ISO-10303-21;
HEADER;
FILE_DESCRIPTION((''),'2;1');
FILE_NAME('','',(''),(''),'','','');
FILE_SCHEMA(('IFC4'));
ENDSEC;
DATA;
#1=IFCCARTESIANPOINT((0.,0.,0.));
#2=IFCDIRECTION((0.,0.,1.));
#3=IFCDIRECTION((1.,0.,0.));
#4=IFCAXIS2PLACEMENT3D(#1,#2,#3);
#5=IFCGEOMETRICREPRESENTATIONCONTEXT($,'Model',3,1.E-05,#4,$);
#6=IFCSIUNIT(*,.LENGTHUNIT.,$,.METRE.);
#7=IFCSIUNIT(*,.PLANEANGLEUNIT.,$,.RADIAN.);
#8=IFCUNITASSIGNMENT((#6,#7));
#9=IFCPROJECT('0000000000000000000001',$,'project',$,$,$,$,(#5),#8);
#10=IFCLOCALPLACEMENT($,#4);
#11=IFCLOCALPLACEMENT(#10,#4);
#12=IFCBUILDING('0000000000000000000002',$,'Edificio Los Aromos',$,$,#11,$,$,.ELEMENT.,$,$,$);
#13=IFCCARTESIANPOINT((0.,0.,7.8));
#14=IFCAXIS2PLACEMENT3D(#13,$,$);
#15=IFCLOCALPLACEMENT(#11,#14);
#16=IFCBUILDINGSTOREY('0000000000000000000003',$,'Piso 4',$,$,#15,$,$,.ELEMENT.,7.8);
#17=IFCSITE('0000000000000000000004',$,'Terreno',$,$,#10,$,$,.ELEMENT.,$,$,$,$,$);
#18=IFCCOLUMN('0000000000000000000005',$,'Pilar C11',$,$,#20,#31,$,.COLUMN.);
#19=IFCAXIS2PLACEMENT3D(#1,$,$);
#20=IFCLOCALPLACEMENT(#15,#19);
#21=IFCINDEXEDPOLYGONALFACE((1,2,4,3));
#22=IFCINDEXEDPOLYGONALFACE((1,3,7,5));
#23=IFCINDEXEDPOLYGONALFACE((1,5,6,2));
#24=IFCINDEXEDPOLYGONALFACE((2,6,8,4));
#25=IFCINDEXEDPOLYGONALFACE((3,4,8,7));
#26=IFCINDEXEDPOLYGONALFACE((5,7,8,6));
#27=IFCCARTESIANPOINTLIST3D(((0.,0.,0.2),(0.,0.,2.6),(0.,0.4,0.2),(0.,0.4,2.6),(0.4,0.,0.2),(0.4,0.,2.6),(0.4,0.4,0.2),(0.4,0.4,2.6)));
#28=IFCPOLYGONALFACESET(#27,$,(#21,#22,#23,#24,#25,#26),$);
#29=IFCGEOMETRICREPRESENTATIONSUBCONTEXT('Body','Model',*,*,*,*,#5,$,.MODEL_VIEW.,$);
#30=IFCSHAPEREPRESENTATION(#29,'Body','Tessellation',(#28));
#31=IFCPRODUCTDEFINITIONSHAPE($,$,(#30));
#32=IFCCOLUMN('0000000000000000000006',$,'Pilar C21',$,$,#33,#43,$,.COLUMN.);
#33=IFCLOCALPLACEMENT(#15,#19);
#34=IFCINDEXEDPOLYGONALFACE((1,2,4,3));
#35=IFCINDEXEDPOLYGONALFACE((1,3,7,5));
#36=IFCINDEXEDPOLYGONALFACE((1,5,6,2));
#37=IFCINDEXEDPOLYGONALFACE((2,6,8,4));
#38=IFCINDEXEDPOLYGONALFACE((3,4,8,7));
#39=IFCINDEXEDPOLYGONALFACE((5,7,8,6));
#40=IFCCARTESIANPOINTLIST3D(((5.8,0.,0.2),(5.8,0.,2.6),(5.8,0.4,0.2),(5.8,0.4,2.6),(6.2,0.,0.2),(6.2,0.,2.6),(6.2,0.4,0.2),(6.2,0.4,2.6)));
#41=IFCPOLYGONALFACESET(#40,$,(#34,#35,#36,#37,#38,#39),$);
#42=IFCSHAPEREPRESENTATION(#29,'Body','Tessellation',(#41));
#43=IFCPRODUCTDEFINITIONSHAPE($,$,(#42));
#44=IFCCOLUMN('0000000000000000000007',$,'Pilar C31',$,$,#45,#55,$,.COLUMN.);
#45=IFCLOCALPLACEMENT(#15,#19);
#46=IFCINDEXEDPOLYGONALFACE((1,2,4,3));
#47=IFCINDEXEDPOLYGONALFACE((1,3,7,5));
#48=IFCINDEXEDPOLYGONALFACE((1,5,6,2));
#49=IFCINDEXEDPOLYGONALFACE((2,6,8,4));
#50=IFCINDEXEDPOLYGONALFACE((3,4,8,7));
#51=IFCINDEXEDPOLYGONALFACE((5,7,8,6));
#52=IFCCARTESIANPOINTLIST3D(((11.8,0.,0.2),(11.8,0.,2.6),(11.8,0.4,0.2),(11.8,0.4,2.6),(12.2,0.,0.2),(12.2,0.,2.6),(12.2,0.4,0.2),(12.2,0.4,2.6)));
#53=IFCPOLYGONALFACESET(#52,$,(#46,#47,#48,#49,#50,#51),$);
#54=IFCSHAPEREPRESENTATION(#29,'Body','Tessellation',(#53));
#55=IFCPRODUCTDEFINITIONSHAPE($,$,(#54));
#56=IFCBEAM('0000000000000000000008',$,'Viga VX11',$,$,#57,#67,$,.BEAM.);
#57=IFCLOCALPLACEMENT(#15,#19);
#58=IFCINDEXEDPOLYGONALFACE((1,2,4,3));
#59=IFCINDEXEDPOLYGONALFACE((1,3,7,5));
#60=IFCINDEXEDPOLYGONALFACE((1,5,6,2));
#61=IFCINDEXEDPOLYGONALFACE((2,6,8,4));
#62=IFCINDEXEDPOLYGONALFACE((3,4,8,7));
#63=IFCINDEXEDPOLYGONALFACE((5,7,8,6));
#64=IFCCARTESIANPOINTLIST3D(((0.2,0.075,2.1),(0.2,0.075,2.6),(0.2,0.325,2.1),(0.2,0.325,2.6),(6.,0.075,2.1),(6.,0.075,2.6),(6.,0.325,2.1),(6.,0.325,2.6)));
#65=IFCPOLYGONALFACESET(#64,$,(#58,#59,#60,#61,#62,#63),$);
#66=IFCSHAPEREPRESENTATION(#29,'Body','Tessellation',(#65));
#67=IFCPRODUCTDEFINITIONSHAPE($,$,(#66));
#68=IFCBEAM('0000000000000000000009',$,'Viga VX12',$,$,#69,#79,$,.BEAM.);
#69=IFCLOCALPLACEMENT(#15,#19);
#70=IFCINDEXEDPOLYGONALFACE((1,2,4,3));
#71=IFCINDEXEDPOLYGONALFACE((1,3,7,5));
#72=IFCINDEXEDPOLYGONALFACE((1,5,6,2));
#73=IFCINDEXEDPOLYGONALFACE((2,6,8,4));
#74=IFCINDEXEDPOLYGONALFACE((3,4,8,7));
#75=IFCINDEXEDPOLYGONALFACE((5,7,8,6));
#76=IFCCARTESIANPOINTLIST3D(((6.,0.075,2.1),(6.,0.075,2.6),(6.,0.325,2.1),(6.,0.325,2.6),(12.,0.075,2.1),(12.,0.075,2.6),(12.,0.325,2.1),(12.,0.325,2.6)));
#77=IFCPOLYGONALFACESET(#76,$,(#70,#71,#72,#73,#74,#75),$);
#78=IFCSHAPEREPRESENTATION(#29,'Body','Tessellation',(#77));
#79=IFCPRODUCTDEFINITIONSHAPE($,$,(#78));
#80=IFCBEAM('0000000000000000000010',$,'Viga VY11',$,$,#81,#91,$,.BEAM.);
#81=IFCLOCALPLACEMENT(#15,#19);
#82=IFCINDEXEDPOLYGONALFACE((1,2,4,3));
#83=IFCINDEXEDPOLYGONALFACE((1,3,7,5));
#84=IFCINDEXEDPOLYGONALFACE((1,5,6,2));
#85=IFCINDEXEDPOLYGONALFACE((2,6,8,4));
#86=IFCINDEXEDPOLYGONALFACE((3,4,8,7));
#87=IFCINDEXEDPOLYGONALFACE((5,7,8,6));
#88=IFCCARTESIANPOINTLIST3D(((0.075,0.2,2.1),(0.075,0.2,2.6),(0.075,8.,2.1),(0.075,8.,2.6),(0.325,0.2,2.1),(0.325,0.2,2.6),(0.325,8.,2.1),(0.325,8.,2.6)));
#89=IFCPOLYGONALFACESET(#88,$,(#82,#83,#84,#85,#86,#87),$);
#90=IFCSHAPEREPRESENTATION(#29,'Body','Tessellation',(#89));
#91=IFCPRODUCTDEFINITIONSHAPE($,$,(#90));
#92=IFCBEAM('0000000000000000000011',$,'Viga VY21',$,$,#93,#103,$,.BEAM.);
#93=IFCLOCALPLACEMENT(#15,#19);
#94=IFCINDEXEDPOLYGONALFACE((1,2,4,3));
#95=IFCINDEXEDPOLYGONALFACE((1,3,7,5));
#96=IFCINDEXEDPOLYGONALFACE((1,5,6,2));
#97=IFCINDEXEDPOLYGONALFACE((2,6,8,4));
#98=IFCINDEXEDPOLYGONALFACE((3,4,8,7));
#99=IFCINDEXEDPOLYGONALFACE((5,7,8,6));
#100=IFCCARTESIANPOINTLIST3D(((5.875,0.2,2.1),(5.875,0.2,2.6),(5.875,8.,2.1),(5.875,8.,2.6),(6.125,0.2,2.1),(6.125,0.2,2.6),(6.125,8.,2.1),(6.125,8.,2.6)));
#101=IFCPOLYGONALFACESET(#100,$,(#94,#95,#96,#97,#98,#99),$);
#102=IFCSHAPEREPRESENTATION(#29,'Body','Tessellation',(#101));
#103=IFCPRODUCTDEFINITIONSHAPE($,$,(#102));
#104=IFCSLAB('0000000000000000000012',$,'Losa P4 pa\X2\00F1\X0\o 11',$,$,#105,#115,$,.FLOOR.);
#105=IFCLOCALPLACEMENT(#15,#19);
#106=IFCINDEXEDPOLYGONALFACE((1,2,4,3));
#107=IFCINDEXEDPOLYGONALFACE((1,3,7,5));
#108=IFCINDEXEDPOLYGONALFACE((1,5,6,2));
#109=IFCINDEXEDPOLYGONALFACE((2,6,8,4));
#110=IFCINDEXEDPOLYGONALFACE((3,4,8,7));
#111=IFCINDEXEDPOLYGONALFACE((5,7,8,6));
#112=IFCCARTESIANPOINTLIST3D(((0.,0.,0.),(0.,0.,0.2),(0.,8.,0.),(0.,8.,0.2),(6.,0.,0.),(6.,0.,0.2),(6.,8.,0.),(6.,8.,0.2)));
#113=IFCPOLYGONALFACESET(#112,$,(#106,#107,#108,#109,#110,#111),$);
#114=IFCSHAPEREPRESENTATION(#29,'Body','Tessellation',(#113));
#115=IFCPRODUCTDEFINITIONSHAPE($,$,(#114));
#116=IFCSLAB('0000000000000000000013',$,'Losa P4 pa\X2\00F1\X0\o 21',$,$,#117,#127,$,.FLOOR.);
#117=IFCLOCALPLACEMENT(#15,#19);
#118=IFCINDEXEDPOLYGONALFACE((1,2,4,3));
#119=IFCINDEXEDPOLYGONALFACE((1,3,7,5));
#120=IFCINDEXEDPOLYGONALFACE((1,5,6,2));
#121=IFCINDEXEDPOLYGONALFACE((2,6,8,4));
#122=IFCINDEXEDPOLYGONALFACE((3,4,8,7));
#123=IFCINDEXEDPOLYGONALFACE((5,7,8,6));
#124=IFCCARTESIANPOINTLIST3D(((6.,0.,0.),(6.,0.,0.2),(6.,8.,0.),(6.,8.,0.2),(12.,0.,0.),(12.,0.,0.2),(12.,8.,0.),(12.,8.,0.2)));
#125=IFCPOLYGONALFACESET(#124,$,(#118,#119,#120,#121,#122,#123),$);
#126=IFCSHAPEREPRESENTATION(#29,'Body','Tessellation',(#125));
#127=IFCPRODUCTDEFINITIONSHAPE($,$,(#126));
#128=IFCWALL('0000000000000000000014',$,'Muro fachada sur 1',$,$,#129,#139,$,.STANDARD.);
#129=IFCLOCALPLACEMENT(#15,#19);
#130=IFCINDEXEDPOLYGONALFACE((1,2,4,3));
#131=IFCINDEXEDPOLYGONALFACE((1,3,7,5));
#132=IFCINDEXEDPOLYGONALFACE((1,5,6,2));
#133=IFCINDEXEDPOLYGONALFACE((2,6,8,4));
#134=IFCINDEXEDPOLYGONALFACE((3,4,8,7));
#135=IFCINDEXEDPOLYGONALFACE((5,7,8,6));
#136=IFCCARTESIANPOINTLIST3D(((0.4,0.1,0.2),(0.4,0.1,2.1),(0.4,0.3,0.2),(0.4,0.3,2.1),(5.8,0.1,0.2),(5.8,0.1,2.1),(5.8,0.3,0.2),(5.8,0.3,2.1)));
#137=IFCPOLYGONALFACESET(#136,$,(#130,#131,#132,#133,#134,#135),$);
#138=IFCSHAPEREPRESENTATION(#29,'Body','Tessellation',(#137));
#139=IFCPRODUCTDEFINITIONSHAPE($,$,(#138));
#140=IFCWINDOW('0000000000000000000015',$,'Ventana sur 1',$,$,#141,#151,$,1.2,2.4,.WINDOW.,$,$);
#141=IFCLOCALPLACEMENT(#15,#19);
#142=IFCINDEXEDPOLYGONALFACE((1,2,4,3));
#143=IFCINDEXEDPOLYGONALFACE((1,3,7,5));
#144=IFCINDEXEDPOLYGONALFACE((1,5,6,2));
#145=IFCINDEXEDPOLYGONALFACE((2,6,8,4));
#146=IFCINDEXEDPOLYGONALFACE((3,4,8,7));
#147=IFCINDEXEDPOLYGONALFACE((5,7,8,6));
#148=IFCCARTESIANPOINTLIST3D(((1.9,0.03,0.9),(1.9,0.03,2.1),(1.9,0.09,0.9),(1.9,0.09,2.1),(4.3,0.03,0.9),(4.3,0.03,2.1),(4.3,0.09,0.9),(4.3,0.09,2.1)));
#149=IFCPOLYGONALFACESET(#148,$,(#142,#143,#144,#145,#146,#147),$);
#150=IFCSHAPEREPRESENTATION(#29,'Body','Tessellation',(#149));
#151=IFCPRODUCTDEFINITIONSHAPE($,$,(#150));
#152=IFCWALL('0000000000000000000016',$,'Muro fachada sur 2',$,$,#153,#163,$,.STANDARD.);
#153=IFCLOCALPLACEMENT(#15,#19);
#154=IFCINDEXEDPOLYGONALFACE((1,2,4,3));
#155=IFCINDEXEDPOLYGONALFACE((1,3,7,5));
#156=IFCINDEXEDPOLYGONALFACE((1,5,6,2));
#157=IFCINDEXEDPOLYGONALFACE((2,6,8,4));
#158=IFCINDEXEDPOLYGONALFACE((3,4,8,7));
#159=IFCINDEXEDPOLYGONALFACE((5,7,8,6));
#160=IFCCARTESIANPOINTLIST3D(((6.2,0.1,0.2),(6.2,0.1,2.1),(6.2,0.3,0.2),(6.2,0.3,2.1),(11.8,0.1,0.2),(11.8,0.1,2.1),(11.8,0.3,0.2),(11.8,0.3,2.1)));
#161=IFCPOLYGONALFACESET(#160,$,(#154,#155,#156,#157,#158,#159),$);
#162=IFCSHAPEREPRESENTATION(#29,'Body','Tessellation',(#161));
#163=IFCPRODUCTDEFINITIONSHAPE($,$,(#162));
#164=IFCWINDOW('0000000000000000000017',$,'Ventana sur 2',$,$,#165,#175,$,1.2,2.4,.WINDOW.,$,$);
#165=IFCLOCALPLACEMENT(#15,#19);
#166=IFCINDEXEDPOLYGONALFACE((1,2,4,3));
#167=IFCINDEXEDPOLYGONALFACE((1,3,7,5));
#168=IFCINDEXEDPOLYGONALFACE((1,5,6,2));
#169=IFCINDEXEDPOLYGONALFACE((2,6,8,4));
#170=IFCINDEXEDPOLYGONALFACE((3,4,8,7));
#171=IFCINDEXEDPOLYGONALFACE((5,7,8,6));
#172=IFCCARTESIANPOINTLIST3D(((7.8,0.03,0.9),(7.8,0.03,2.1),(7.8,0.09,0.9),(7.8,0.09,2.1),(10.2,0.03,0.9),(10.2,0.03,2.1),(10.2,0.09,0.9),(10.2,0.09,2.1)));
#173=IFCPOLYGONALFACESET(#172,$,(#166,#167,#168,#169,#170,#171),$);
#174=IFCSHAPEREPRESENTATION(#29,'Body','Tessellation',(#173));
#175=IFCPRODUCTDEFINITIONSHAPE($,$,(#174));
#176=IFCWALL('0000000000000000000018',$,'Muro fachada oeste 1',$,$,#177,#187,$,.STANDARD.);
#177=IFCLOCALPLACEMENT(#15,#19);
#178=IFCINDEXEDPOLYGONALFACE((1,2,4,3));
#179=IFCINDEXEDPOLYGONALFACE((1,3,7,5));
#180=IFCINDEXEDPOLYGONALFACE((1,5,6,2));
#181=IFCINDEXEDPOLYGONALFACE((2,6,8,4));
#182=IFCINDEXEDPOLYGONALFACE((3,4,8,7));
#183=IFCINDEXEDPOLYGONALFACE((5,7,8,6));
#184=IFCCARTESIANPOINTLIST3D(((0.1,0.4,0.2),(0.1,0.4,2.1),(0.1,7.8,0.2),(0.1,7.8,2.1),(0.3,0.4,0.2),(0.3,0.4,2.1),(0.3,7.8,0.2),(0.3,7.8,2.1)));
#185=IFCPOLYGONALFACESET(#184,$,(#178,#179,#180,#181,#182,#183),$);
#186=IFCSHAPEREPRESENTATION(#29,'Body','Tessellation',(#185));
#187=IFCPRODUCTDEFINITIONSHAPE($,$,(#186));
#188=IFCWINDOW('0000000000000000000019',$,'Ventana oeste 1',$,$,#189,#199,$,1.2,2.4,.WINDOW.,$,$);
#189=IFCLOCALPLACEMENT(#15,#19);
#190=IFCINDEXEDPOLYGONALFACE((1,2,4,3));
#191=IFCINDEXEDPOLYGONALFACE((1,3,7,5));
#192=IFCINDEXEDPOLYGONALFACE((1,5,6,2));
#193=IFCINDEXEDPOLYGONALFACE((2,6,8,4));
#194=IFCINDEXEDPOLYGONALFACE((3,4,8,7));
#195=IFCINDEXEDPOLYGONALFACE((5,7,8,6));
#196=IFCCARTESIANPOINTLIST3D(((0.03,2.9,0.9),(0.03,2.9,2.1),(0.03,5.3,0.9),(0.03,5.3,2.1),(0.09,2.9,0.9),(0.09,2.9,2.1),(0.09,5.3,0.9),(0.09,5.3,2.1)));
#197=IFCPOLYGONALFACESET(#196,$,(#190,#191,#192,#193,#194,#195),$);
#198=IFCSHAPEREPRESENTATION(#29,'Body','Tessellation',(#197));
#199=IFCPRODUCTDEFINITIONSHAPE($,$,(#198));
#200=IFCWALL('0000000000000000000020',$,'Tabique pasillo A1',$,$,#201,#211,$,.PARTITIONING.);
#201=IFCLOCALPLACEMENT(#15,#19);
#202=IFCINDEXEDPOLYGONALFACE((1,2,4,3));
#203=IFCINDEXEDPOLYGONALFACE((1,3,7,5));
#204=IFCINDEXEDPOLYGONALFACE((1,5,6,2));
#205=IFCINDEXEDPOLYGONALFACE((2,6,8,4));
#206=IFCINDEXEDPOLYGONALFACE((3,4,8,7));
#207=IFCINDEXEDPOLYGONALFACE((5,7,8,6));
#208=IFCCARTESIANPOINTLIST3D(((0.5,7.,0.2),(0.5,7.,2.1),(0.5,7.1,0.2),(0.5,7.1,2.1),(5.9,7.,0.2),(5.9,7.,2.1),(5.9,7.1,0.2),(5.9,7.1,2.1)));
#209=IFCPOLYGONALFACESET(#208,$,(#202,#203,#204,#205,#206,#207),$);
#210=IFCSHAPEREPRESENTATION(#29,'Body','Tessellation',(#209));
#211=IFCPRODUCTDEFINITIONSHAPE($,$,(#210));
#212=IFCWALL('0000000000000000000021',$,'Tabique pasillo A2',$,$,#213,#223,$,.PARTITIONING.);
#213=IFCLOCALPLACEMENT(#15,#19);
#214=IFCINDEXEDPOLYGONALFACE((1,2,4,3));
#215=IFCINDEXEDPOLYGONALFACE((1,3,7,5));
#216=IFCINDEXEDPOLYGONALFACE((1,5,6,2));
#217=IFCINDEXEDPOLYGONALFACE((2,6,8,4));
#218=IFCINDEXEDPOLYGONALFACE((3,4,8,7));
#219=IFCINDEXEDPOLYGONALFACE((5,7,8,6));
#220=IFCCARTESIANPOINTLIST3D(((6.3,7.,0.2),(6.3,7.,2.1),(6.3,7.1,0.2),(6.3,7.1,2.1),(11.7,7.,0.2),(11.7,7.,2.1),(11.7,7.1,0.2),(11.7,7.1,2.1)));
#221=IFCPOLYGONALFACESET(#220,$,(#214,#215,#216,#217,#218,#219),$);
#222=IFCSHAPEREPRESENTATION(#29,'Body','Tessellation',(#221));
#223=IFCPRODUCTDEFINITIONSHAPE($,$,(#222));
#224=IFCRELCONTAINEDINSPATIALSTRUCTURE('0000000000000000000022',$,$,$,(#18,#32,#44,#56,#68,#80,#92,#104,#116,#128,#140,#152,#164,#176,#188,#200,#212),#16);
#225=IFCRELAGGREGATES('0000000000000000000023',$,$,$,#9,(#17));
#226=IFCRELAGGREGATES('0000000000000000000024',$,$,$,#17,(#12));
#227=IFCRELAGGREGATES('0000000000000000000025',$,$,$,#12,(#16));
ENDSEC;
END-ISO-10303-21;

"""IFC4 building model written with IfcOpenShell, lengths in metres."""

from ifc_helpers import new_model, si_unit, frame, frame_2d, origin_with_axes, place, context, subcontext, project, spatial, rectangle, extrude, element, save


model = new_model("IFC4")

# Units and contexts
model_context = context("Model", 3, precision=1e-05, world=origin_with_axes())
body_context = subcontext(model_context, "Body", "Model", "MODEL_VIEW")
ifc_project = project(units=[si_unit("LENGTHUNIT", "METRE"), si_unit("PLANEANGLEUNIT", "RADIAN")], contexts=[model_context])

# Site, building, storey
site_placement = place(None, origin_with_axes())
site = spatial("IfcSite", under=ifc_project, at=site_placement, Name="Terreno", CompositionType="ELEMENT")
building_placement = place(site_placement, origin_with_axes())
building = spatial("IfcBuilding", under=site, at=building_placement, Name="Edificio Los Aromos", CompositionType="ELEMENT")
storey_placement = place(building_placement, frame((0.0, 0.0, 7.8)))
storey = spatial("IfcBuildingStorey", under=building, at=storey_placement, Name="Piso 4", CompositionType="ELEMENT", Elevation=7.8)

# Columns
for number, where, name in (
    (1, (0.0, 0.0, 0.2), "Pilar C11"),
    (2, (5.8, 0.0, 0.2), "Pilar C21"),
    (3, (11.8, 0.0, 0.2), "Pilar C31"),
):
    element("IfcColumn", number, at=place(storey_placement, frame(where)), inside=storey, Name=name, PredefinedType="COLUMN", context=body_context, shape_type="SweptSolid", body=[
        extrude(rectangle(XDim=0.4, YDim=0.4, at=frame_2d((0.2, 0.2))), origin_with_axes(), (0.0, 0.0, 1.0), 2.4),
    ])

# Beams
beam_1_placement = place(storey_placement, frame((0.2, 0.075, 2.1)))
element("IfcBeam", 4, at=beam_1_placement, inside=storey, Name="Viga VX11", PredefinedType="BEAM", context=body_context, shape_type="SweptSolid", body=[
    extrude(rectangle(XDim=5.8, YDim=0.25, at=frame_2d((2.9, 0.125))), origin_with_axes(), (0.0, 0.0, 1.0), 0.5),
])
beam_2_placement = place(storey_placement, frame((6.0, 0.075, 2.1)))
element("IfcBeam", 5, at=beam_2_placement, inside=storey, Name="Viga VX12", PredefinedType="BEAM", context=body_context, shape_type="SweptSolid", body=[
    extrude(rectangle(XDim=6.0, YDim=0.25, at=frame_2d((3.0, 0.125))), origin_with_axes(), (0.0, 0.0, 1.0), 0.5),
])
for number, where, name in (
    (6, (0.075, 0.2, 2.1), "Viga VY11"),
    (7, (5.875, 0.2, 2.1), "Viga VY21"),
):
    element("IfcBeam", number, at=place(storey_placement, frame(where)), inside=storey, Name=name, PredefinedType="BEAM", context=body_context, shape_type="SweptSolid", body=[
        extrude(rectangle(XDim=0.25, YDim=7.8, at=frame_2d((0.125, 3.9))), origin_with_axes(), (0.0, 0.0, 1.0), 0.5),
    ])

# Slabs
for number, where, name in (
    (8, (0.0, 0.0, 0.0), "Losa P4 paño 11"),
    (9, (6.0, 0.0, 0.0), "Losa P4 paño 21"),
):
    element("IfcSlab", number, at=place(storey_placement, frame(where)), inside=storey, Name=name, PredefinedType="FLOOR", context=body_context, shape_type="SweptSolid", body=[
        extrude(rectangle(XDim=6.0, YDim=8.0, at=frame_2d((3.0, 4.0))), origin_with_axes(), (0.0, 0.0, 1.0), 0.2),
    ])

# Wall
wall_1_placement = place(storey_placement, frame((0.4, 0.1, 0.2)))
element("IfcWall", 10, at=wall_1_placement, inside=storey, Name="Muro fachada sur 1", PredefinedType="STANDARD", context=body_context, shape_type="SweptSolid", body=[
    extrude(rectangle(XDim=5.4, YDim=0.2, at=frame_2d((2.7, 0.1))), origin_with_axes(), (0.0, 0.0, 1.0), 1.9),
])

# Window
window_1_placement = place(storey_placement, frame((1.9, 0.03, 0.9)))
element("IfcWindow", 11, at=window_1_placement, inside=storey, Name="Ventana sur 1", OverallHeight=1.2, OverallWidth=2.4, PredefinedType="WINDOW", context=body_context, shape_type="SweptSolid", body=[
    extrude(rectangle(XDim=2.4, YDim=0.06, at=frame_2d((1.2, 0.03))), origin_with_axes(), (0.0, 0.0, 1.0), 1.2),
])

# Wall
wall_2_placement = place(storey_placement, frame((6.2, 0.1, 0.2)))
element("IfcWall", 12, at=wall_2_placement, inside=storey, Name="Muro fachada sur 2", PredefinedType="STANDARD", context=body_context, shape_type="SweptSolid", body=[
    extrude(rectangle(XDim=5.6, YDim=0.2, at=frame_2d((2.8, 0.1))), origin_with_axes(), (0.0, 0.0, 1.0), 1.9),
])

# Window
window_2_placement = place(storey_placement, frame((7.8, 0.03, 0.9)))
element("IfcWindow", 13, at=window_2_placement, inside=storey, Name="Ventana sur 2", OverallHeight=1.2, OverallWidth=2.4, PredefinedType="WINDOW", context=body_context, shape_type="SweptSolid", body=[
    extrude(rectangle(XDim=2.4, YDim=0.06, at=frame_2d((1.2, 0.03))), origin_with_axes(), (0.0, 0.0, 1.0), 1.2),
])

# Wall
wall_3_placement = place(storey_placement, frame((0.1, 0.4, 0.2)))
element("IfcWall", 14, at=wall_3_placement, inside=storey, Name="Muro fachada oeste 1", PredefinedType="STANDARD", context=body_context, shape_type="SweptSolid", body=[
    extrude(rectangle(XDim=0.2, YDim=7.4, at=frame_2d((0.1, 3.7))), origin_with_axes(), (0.0, 0.0, 1.0), 1.9),
])

# Window
window_3_placement = place(storey_placement, frame((0.03, 2.9, 0.9)))
element("IfcWindow", 15, at=window_3_placement, inside=storey, Name="Ventana oeste 1", OverallHeight=1.2, OverallWidth=2.4, PredefinedType="WINDOW", context=body_context, shape_type="SweptSolid", body=[
    extrude(rectangle(XDim=0.06, YDim=2.4, at=frame_2d((0.03, 1.2))), origin_with_axes(), (0.0, 0.0, 1.0), 1.2),
])

# Walls
for number, where, name in (
    (16, (0.5, 7.0, 0.2), "Tabique pasillo A1"),
    (17, (6.3, 7.0, 0.2), "Tabique pasillo A2"),
):
    element("IfcWall", number, at=place(storey_placement, frame(where)), inside=storey, Name=name, PredefinedType="PARTITIONING", context=body_context, shape_type="SweptSolid", body=[
        extrude(rectangle(XDim=5.4, YDim=0.1, at=frame_2d((2.7, 0.05))), origin_with_axes(), (0.0, 0.0, 1.0), 1.9),
    ])

save(model, "model.ifc")
